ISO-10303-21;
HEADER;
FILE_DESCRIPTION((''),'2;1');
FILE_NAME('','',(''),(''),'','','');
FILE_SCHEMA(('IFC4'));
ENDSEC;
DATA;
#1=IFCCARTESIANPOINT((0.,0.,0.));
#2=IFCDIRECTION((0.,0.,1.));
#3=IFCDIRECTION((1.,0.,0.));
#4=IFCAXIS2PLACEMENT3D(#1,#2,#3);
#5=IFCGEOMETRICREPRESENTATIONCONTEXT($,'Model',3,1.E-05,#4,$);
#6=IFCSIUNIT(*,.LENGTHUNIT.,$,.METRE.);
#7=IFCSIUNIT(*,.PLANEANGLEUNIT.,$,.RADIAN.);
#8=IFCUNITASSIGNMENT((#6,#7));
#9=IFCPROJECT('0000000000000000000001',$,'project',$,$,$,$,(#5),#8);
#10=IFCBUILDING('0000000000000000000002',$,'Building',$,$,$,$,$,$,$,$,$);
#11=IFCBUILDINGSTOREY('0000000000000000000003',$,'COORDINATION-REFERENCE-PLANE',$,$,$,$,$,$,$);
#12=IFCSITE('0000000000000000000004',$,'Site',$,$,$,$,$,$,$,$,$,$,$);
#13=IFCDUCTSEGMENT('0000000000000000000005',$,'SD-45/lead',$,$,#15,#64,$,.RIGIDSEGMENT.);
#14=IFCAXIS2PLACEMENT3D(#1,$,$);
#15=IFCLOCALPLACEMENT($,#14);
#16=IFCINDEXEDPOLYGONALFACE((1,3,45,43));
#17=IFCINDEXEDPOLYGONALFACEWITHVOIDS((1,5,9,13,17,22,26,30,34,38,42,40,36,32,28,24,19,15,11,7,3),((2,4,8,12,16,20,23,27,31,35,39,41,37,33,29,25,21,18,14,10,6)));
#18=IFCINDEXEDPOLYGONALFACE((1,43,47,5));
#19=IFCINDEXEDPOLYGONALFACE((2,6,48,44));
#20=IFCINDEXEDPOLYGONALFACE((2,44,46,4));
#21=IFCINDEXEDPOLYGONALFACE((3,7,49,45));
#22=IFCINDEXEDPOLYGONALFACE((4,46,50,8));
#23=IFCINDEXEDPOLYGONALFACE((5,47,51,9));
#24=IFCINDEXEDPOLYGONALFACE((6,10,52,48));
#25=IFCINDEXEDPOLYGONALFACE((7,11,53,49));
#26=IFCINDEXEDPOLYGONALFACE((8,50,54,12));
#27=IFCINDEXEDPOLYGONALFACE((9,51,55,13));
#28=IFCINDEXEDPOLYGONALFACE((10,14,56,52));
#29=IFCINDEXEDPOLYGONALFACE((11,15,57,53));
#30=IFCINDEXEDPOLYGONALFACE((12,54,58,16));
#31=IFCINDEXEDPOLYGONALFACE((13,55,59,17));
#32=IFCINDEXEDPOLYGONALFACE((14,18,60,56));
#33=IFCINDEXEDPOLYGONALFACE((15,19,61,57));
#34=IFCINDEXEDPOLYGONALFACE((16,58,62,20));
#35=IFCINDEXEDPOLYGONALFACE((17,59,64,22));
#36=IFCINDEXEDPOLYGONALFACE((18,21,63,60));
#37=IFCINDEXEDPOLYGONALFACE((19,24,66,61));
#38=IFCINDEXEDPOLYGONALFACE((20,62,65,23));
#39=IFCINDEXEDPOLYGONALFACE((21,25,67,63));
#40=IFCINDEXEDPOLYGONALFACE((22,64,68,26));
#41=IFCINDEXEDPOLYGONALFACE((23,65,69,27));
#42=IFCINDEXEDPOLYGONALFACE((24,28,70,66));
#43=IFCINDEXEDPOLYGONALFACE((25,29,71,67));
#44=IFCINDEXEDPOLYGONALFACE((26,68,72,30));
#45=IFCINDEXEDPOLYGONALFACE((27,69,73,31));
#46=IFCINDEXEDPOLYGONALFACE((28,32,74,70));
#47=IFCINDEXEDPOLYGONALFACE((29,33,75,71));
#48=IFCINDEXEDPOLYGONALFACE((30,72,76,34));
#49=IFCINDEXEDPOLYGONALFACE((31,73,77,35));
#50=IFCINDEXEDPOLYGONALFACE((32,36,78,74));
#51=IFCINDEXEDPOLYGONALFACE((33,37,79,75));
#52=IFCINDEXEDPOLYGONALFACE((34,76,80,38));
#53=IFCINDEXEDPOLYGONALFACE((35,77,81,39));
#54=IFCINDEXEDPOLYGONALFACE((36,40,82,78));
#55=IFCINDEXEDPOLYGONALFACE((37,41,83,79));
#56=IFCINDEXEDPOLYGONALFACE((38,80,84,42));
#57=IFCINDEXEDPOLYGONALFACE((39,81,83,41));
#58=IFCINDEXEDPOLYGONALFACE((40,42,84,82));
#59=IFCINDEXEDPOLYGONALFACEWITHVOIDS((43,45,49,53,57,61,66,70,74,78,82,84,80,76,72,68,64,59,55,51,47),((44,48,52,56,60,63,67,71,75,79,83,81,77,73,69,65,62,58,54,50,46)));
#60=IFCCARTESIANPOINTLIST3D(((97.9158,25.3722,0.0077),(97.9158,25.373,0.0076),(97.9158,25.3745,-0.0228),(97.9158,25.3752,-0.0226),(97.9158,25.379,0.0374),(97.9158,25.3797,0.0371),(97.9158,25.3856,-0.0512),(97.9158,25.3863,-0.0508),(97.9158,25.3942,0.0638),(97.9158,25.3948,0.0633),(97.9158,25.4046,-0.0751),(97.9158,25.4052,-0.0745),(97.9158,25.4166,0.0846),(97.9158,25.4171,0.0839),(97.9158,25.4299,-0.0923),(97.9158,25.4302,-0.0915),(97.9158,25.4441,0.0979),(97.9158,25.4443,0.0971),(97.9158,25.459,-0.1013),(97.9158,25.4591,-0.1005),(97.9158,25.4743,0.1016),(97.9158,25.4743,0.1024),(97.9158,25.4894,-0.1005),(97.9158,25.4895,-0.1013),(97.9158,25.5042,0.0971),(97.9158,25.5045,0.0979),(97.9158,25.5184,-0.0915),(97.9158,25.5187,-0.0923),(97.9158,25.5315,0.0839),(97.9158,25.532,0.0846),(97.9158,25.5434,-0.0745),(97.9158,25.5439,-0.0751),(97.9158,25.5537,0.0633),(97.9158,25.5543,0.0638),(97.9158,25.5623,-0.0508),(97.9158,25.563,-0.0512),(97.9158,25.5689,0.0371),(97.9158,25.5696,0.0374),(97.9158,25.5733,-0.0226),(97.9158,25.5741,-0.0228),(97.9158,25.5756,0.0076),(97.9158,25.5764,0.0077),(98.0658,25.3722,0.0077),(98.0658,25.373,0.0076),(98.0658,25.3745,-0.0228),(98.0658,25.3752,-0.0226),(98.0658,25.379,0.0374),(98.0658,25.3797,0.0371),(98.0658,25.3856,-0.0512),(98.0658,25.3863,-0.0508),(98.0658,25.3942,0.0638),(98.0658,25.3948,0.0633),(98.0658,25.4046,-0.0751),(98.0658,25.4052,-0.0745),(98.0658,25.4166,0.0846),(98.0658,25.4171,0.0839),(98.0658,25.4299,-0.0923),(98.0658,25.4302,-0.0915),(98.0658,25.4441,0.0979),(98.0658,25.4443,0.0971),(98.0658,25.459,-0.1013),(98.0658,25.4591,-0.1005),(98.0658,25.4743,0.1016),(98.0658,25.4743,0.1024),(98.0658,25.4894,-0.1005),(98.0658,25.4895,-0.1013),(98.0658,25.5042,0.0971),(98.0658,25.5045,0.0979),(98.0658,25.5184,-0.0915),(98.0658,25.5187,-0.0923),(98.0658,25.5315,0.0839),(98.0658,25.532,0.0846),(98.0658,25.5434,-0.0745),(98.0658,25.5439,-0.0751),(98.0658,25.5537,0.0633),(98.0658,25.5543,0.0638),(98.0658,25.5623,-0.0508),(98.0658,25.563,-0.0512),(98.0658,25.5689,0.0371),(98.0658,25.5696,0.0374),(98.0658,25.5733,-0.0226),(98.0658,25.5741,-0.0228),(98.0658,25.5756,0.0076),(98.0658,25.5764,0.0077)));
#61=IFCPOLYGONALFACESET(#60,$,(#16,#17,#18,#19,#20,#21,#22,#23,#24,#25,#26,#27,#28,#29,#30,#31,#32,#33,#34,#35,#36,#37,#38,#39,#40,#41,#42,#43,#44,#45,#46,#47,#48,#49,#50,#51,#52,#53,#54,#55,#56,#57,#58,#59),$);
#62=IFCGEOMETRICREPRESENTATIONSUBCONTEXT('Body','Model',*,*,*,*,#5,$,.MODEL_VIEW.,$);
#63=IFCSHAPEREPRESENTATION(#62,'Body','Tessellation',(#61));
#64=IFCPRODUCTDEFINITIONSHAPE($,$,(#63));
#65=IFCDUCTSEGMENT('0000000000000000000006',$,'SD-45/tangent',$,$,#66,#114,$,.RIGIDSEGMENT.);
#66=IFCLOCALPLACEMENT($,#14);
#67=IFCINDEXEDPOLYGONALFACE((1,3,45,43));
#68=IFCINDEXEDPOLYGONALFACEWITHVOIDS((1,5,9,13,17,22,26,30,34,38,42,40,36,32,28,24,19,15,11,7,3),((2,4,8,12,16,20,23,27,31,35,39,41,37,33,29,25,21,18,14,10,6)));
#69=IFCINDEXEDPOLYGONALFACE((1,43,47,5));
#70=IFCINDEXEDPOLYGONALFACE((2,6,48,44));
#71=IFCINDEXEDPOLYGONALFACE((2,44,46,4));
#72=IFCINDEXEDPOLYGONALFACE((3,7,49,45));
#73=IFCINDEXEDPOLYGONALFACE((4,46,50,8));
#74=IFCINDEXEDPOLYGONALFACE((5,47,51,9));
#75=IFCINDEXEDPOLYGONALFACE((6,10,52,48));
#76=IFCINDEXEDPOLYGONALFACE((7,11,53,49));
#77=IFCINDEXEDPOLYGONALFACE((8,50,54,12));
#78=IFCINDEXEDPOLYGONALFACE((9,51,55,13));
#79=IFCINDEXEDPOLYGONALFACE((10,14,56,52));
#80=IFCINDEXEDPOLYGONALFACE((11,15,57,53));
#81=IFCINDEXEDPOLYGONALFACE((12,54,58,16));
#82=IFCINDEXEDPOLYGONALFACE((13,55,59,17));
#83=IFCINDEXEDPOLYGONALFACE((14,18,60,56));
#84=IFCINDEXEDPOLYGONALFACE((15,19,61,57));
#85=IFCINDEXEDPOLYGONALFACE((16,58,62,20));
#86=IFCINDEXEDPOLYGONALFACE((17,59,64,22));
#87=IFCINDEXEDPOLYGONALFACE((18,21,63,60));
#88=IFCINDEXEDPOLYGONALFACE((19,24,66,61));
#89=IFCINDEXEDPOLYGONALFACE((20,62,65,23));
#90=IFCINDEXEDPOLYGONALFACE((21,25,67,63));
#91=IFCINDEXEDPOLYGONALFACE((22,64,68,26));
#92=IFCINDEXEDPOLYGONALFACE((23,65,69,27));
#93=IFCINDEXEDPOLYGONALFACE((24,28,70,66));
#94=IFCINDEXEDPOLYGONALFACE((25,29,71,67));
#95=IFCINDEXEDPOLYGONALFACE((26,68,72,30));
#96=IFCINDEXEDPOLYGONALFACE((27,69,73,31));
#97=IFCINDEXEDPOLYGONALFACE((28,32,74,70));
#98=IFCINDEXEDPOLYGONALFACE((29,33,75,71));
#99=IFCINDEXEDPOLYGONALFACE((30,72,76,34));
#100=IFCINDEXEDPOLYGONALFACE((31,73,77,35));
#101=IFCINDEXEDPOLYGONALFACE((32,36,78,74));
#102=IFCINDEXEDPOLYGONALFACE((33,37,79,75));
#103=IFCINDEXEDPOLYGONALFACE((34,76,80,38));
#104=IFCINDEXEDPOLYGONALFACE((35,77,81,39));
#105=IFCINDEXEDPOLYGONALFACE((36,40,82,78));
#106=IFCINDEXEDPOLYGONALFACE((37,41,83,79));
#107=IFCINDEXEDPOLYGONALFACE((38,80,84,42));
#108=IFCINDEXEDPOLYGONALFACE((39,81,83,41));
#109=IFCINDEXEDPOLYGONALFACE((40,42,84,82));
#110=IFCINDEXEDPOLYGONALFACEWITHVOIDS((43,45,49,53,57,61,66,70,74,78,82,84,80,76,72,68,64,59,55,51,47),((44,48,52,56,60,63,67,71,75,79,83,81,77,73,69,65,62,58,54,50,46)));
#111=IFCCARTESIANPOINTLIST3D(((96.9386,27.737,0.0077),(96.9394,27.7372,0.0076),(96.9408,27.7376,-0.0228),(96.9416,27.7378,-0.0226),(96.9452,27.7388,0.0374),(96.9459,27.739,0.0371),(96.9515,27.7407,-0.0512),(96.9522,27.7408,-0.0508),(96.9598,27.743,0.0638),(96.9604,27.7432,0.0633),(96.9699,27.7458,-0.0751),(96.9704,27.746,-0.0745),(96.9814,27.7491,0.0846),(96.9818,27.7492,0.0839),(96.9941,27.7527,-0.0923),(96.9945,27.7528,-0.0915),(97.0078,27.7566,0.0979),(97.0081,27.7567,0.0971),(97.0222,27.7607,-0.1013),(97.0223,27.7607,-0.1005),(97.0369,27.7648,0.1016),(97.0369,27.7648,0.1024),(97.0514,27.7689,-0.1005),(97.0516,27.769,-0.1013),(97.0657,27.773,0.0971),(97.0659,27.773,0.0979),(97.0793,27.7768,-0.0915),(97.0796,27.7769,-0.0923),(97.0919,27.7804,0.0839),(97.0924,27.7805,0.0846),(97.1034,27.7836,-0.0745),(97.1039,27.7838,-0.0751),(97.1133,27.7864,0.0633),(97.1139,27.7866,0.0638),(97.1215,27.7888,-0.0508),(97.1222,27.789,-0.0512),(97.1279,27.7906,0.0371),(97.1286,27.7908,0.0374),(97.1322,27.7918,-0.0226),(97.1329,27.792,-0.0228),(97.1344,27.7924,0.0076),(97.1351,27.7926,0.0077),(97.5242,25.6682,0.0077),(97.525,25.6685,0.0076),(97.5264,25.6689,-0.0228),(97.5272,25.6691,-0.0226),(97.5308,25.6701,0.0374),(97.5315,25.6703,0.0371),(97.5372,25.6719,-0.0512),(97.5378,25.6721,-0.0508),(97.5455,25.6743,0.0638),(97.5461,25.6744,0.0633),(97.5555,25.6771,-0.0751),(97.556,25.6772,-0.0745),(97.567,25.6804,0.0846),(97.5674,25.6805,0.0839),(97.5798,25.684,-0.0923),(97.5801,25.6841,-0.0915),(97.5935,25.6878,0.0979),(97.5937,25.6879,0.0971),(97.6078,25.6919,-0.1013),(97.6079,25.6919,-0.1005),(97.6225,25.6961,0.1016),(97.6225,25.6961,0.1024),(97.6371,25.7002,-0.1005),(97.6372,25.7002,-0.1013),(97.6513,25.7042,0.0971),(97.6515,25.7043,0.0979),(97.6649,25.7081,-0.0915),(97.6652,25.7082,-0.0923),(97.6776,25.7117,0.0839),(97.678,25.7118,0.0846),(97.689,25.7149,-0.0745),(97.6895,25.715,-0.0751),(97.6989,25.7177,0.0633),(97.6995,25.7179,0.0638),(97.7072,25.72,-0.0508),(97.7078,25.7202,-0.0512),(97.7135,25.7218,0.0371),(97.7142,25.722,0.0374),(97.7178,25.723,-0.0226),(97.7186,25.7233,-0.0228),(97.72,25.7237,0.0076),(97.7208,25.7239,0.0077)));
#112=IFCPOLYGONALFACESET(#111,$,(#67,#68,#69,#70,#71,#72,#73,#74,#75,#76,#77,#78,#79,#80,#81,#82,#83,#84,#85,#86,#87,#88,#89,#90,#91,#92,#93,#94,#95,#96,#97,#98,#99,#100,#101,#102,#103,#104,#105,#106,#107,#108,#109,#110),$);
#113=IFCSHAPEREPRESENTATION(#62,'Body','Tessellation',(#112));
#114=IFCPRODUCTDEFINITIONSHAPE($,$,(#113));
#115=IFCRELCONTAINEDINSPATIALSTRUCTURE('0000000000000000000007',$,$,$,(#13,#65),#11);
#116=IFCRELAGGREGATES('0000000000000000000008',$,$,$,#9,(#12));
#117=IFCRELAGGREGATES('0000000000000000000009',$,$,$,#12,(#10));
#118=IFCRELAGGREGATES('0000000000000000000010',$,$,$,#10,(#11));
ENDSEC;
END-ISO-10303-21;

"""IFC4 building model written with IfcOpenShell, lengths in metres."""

from ifc_helpers import new_model, si_unit, frame, origin_with_axes, place, context, subcontext, project, spatial, hollow_circle, extrude, element, save


model = new_model("IFC4")

# Units and contexts
model_context = context("Model", 3, precision=1e-05, world=origin_with_axes())
body_context_1 = subcontext(model_context, "Body", "Model", "MODEL_VIEW")
ifc_project = project(units=[si_unit("LENGTHUNIT", "METRE"), si_unit("PLANEANGLEUNIT", "RADIAN")], contexts=[model_context])

# Site, building, storey
site = spatial("IfcSite", under=ifc_project, Name="Site")
building = spatial("IfcBuilding", under=site, Name="Building")
storey = spatial("IfcBuildingStorey", under=building, Name="COORDINATION-REFERENCE-PLANE")

# Duct segment
duct_segment_1_placement = place(None, frame((98.0658, 25.4743, 0.0), z_axis=(-1.0, 0.0, 0.0), x_axis=(0.0, 0.0, 1.0)))
element("IfcDuctSegment", 1, at=duct_segment_1_placement, inside=storey, Name="SD-45/lead", PredefinedType="RIGIDSEGMENT", context=body_context_1, shape_type="SweptSolid", body=[
    extrude(hollow_circle(Radius=0.1024, WallThickness=0.0008), origin_with_axes(), (0.0, 0.0, 1.0), 0.15),
])

# Duct segment
duct_segment_2_placement = place(None, frame((97.6225, 25.6961, 0.0), z_axis=(-0.272381, 0.96219, 0.0), x_axis=(0.0, 0.0, 1.0)))
element("IfcDuctSegment", 2, at=duct_segment_2_placement, inside=storey, Name="SD-45/tangent", PredefinedType="RIGIDSEGMENT", context=body_context_1, shape_type="SweptSolid", body=[
    extrude(hollow_circle(Radius=0.1024, WallThickness=0.0008), origin_with_axes(), (0.0, 0.0, 1.0), 2.15),
])

save(model, "model.ifc")
